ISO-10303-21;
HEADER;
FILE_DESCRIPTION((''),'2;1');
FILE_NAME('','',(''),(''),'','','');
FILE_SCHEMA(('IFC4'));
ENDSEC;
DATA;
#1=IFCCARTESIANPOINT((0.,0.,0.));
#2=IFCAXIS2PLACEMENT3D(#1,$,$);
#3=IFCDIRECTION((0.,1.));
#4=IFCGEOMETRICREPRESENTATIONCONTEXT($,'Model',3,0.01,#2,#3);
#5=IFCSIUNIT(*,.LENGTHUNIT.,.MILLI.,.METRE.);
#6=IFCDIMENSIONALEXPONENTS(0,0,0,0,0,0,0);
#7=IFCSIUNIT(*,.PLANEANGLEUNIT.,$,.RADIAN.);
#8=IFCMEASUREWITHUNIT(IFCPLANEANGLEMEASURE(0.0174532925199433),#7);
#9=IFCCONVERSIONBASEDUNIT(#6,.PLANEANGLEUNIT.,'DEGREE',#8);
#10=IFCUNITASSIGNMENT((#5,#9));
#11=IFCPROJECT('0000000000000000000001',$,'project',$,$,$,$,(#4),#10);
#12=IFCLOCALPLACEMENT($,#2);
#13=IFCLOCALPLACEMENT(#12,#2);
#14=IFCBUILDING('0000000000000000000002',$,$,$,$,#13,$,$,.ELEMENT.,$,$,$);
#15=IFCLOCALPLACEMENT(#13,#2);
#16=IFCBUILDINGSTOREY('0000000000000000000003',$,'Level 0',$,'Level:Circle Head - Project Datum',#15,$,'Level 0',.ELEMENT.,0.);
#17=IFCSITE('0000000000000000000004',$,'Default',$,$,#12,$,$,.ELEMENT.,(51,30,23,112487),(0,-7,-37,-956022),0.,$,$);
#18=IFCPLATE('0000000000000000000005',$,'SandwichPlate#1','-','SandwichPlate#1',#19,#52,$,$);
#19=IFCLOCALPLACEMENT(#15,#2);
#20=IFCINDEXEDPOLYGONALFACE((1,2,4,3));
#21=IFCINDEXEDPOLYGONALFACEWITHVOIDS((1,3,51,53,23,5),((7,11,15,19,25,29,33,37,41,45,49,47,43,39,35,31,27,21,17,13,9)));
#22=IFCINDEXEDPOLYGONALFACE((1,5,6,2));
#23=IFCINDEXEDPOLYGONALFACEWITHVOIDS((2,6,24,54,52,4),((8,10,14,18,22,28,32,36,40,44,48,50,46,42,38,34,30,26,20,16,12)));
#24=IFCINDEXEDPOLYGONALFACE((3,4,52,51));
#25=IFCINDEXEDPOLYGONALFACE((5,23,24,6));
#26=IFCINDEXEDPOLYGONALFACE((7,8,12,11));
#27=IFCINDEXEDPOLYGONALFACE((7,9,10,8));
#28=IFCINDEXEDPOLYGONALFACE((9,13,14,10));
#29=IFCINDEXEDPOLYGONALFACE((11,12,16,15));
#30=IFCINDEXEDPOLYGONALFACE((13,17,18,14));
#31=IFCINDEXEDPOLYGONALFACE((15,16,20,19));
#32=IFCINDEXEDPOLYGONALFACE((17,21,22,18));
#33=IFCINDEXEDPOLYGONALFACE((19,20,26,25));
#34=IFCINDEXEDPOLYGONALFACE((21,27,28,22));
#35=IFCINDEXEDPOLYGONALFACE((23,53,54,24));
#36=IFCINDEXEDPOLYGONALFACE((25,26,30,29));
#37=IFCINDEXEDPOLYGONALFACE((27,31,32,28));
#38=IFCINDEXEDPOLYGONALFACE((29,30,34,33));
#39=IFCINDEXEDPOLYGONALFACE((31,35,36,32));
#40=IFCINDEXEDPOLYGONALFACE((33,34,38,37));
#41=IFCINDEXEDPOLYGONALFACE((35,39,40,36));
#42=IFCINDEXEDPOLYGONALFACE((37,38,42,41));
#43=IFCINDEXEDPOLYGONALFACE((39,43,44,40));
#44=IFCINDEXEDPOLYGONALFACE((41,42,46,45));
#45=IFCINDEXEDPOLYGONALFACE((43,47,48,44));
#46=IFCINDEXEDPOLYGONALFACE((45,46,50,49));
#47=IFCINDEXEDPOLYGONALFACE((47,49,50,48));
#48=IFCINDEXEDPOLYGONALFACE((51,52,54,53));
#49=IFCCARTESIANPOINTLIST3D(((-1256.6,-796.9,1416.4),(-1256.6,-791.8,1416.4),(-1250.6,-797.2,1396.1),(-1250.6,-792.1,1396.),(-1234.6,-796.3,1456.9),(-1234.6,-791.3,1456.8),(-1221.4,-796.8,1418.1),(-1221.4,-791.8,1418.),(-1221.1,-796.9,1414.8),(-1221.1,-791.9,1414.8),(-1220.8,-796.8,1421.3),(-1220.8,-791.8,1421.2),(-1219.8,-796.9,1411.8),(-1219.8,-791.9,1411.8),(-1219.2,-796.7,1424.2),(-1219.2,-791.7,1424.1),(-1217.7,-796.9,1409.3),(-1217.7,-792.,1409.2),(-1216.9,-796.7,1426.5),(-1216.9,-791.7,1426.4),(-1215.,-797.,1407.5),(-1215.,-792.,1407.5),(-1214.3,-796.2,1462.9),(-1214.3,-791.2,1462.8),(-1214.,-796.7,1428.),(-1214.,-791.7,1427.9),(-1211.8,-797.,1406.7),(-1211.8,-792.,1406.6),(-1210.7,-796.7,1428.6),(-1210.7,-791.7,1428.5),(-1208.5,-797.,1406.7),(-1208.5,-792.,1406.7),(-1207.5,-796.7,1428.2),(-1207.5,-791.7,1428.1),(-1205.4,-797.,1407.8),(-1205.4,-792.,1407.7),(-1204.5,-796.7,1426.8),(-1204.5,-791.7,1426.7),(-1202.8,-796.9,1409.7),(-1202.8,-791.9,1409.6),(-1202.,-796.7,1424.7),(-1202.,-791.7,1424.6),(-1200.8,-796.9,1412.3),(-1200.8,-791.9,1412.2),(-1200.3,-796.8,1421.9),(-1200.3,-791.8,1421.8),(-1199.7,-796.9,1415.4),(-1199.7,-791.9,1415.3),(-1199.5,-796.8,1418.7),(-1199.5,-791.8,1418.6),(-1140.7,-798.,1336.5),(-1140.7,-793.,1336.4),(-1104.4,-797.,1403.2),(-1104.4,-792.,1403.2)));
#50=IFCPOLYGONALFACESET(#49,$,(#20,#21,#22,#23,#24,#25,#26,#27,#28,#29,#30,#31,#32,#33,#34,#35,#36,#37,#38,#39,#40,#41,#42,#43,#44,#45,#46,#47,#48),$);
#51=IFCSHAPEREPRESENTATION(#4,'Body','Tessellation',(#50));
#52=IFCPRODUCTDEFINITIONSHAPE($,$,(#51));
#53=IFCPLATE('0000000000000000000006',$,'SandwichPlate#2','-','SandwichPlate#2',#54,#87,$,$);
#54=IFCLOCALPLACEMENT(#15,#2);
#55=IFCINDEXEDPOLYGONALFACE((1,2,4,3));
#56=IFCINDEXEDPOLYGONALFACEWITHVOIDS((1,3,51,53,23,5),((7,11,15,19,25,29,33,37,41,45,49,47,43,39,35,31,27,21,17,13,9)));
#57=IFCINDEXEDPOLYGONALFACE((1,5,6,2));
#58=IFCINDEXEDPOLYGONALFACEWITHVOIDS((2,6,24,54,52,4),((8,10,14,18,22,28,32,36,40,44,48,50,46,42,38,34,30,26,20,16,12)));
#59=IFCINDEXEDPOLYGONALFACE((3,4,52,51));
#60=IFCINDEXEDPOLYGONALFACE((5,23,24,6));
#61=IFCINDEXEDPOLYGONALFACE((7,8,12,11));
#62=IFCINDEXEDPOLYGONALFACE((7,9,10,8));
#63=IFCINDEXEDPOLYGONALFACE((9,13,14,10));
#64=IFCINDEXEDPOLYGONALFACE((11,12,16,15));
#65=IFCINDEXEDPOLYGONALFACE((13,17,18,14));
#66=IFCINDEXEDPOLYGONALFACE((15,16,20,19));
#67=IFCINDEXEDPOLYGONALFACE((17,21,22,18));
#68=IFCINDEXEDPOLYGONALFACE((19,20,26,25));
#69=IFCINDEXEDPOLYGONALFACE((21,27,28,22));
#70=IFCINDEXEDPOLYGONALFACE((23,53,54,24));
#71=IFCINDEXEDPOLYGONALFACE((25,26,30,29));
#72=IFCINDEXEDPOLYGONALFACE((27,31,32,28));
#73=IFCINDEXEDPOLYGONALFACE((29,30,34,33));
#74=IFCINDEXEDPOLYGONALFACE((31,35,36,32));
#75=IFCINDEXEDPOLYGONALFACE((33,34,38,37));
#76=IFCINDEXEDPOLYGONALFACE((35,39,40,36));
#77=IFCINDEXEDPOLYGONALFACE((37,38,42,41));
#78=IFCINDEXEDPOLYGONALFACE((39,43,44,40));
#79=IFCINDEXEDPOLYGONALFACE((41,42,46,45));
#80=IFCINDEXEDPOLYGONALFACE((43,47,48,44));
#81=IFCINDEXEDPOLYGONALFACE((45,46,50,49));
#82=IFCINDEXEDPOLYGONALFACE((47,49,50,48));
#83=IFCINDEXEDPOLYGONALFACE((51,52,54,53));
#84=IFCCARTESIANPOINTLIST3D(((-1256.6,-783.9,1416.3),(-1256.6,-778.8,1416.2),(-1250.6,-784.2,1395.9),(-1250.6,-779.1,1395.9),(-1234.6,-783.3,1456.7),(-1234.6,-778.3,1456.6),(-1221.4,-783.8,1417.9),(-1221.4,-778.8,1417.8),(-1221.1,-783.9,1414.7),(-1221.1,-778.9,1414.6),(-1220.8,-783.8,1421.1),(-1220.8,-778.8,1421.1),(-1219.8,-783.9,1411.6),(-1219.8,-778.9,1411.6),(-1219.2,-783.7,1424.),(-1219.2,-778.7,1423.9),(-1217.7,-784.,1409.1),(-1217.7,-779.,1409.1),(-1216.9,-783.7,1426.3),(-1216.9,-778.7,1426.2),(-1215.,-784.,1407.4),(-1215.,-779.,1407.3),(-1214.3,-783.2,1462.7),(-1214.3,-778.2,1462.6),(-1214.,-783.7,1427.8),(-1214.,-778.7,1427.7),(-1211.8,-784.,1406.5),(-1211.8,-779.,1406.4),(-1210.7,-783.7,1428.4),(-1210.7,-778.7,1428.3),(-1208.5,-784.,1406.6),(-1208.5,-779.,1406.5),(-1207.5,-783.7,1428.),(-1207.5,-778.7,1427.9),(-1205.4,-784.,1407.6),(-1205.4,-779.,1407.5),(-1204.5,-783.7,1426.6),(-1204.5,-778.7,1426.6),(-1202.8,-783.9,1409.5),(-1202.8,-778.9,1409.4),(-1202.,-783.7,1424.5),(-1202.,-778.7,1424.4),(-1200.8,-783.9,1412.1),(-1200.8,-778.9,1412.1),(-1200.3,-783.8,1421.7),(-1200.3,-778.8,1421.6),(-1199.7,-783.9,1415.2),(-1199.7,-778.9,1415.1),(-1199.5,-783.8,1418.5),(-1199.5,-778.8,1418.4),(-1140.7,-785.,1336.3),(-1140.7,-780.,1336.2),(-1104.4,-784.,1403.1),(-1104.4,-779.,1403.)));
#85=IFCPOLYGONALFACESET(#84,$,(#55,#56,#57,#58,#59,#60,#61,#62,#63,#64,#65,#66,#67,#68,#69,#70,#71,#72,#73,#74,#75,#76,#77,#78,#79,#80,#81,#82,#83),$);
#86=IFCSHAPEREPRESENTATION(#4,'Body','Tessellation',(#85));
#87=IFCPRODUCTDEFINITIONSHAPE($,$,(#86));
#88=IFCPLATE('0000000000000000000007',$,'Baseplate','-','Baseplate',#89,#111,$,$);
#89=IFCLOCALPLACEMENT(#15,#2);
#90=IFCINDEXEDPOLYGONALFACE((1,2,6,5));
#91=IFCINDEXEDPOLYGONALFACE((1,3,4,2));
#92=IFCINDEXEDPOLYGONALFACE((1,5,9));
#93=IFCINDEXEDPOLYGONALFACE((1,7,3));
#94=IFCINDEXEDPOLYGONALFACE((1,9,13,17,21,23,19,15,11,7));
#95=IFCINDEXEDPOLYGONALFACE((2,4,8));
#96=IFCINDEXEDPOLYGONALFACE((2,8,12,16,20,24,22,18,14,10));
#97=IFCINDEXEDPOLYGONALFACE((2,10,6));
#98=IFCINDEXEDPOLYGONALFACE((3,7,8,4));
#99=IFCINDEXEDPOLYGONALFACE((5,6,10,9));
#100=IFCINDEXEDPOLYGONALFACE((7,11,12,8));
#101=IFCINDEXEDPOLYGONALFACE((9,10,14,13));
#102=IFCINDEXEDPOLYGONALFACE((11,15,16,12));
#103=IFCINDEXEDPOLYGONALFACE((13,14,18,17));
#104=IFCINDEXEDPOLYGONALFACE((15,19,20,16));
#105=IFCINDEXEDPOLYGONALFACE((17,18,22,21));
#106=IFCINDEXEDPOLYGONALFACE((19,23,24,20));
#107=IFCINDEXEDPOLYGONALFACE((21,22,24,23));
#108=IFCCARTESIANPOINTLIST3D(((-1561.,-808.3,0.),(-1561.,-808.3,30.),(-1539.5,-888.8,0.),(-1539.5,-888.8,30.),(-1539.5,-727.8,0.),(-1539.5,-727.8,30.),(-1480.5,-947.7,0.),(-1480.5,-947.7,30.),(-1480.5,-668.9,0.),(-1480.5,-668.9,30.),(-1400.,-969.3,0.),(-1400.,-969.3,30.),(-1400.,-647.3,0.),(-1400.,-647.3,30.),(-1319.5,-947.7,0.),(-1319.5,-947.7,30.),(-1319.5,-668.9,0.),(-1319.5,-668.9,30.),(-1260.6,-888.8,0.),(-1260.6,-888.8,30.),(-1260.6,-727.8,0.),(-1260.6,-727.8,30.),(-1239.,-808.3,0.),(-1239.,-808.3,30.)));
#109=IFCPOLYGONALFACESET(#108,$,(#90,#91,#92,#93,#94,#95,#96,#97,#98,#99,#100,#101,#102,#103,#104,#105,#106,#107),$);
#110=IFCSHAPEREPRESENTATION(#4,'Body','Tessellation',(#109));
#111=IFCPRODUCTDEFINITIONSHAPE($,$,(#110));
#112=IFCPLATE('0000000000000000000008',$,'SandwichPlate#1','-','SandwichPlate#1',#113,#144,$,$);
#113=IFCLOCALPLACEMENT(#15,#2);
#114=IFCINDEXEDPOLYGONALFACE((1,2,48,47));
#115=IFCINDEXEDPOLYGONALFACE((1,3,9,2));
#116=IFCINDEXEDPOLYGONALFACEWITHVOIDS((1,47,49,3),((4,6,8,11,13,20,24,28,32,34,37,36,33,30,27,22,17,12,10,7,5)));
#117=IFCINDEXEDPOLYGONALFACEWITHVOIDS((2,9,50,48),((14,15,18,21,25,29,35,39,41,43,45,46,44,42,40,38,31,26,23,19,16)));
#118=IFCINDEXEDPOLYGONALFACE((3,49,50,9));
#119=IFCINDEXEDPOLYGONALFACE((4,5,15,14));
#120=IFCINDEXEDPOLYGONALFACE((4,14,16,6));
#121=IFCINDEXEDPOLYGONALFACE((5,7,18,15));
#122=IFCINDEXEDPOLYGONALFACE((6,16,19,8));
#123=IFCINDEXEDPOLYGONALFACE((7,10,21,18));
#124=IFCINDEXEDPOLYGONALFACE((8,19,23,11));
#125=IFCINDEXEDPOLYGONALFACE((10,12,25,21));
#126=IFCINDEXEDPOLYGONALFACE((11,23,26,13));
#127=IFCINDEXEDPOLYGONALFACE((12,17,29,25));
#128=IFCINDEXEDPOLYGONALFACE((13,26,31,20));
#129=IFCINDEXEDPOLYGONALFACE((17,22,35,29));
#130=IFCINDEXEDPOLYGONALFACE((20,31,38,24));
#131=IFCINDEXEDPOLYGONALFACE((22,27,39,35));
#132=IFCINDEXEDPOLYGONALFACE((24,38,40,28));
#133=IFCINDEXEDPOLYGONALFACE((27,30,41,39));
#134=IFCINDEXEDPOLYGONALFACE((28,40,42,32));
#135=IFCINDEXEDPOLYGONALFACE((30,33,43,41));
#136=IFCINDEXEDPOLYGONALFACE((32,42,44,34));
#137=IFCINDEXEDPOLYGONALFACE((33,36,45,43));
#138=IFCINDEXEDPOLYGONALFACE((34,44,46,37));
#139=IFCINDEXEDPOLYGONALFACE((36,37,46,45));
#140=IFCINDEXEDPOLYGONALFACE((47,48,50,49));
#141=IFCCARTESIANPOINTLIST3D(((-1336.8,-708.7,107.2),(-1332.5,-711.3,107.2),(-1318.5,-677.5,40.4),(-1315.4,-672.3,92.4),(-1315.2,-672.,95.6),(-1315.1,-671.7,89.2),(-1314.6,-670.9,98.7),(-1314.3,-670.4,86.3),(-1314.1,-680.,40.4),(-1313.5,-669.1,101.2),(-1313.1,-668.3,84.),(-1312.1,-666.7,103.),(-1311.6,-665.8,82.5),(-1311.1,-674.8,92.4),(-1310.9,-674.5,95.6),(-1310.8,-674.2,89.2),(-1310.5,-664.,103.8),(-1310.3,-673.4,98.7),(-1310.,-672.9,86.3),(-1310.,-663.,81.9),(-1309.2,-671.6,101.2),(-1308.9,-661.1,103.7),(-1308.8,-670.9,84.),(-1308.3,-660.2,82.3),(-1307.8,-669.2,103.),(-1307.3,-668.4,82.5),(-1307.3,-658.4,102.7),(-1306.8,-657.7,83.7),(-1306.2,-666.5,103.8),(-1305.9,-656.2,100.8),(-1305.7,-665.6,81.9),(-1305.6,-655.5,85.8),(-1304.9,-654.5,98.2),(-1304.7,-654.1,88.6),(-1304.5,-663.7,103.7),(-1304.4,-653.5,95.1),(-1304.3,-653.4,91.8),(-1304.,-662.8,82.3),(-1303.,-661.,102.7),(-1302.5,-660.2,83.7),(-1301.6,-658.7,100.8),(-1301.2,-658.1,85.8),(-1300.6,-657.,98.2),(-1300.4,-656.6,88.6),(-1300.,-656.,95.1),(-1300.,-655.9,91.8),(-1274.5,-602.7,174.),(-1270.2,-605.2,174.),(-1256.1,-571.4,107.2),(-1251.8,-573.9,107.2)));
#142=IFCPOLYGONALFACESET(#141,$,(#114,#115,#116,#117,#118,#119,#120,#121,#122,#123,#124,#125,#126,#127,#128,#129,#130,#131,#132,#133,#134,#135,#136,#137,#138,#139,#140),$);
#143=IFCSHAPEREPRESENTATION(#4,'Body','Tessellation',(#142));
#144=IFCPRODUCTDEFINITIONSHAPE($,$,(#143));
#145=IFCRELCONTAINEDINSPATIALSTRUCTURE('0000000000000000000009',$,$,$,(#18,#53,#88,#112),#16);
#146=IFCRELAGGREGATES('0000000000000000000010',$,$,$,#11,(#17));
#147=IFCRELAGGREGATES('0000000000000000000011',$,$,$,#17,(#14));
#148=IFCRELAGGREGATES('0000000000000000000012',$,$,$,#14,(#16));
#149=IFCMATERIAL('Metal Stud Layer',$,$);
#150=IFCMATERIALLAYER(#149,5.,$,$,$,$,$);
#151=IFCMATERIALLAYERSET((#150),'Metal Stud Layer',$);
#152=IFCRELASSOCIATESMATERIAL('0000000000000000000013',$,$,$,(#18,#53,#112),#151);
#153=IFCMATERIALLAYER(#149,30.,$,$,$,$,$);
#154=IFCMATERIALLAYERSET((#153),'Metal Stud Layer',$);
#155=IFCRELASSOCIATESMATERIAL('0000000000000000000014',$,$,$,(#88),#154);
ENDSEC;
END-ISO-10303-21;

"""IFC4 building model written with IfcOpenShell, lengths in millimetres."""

from ifc_helpers import new_model, entity, si_unit, converted_unit, point, direction, frame, frame_2d, origin, origin_with_axes, origin_2d_with_axis, place, context, project, spatial, polyline, circle_curve, line_curve, trimmed, segment, composite_curve, circle, outline, extrude, material, layer, layer_set, element, save


model = new_model("IFC4")

# Units and contexts
model_context = context("Model", 3, precision=0.01, world=origin(), true_north=direction((0.0, 1.0)))
ifc_project = project(units=[si_unit("LENGTHUNIT", "METRE", prefix="MILLI"), converted_unit("PLANEANGLEUNIT", "DEGREE", entity("IfcPlaneAngleMeasure", 0.0174532925199433), si_unit("PLANEANGLEUNIT", "RADIAN"), dimensions=[0, 0, 0, 0, 0, 0, 0])], contexts=[model_context])

# Site, building, storey
site_placement = place(None, origin())
site = spatial("IfcSite", under=ifc_project, at=site_placement, Name="Default", CompositionType="ELEMENT", RefLatitude=(51, 30, 23, 112487), RefLongitude=(0, -7, -37, -956022), RefElevation=0.0)
building_placement = place(site_placement, origin())
building = spatial("IfcBuilding", under=site, at=building_placement, CompositionType="ELEMENT")
storey_placement = place(building_placement, origin())
storey = spatial("IfcBuildingStorey", under=building, at=storey_placement, Name="Level 0", ObjectType="Level:Circle Head - Project Datum", LongName="Level 0", CompositionType="ELEMENT", Elevation=0.0)

# Plates, openings
ifc_material_1 = material(Name="Metal Stud Layer")
ifc_layer_1 = layer(ifc_material_1, 5.0)
ifc_layer_set_1 = layer_set([ifc_layer_1], Name="Metal Stud Layer")
plate_1_placement = place(storey_placement, frame((-1263.7, -797.0, 1403.3), z_axis=(0.0, 0.999896, -0.014432), x_axis=(0.477218, 0.012683, 0.878693)))
plate_1 = element("IfcPlate", 1, at=plate_1_placement, inside=storey, material=ifc_layer_set_1, Name="SandwichPlate#1", Description="-", ObjectType="SandwichPlate#1", context=model_context, shape_type="SweptSolid", body=[
    extrude(outline(polyline([(0.0, 0.0), (76.0, 0.0), (76.0, 140.0), (0.0, 140.0), (0.0, 0.0)])), origin_with_axes(), (0.0, 0.0, 1.0), 5.0),
])
opening_1_placement = place(plate_1_placement, frame((0.0, 0.0, 0.0), z_axis=(0.0, 0.0, 1.0), x_axis=(1.0, 0.0, 0.0)))
element("IfcOpeningElement", 2, at=opening_1_placement, cuts=plate_1, ObjectType="Opening", context=model_context, shape_type="SweptSolid", body=[
    extrude(outline(polyline([(0.0, 0.0), (15.0, 0.0), (0.0, 15.0), (0.0, 0.0)])), origin(), (0.0, 0.0, 1.0), 5.0),
])
opening_2_placement = place(plate_1_placement, frame((0.0, 0.0, 0.0), z_axis=(0.0, 0.0, 1.0), x_axis=(1.0, 0.0, 0.0)))
element("IfcOpeningElement", 3, at=opening_2_placement, cuts=plate_1, ObjectType="Opening", context=model_context, shape_type="SweptSolid", body=[
    extrude(outline(polyline([(76.0, 0.0), (76.0, 15.0), (61.0, 0.0), (76.0, 0.0)])), origin(), (0.0, 0.0, 1.0), 5.0),
])
opening_3_placement = place(plate_1_placement, frame((38.0, 40.0, -0.5), z_axis=(0.0, 0.0, 1.0), x_axis=(0.0, 1.0, 0.0)))
element("IfcOpeningElement", 4, at=opening_3_placement, cuts=plate_1, ObjectType="Opening", context=model_context, shape_type="SweptSolid", body=[
    extrude(circle(Radius=11.0, at=origin_2d_with_axis()), origin(), (0.0, 0.0, 1.0), 6.0),
])
plate_2_placement = place(storey_placement, frame((-1263.7, -784.0, 1403.1), z_axis=(0.0, 0.999896, -0.014432), x_axis=(0.477218, 0.012683, 0.878693)))
plate_2 = element("IfcPlate", 5, at=plate_2_placement, inside=storey, material=ifc_layer_set_1, Name="SandwichPlate#2", Description="-", ObjectType="SandwichPlate#2", context=model_context, shape_type="SweptSolid", body=[
    extrude(outline(polyline([(0.0, 0.0), (76.0, 0.0), (76.0, 140.0), (0.0, 140.0), (0.0, 0.0)])), origin_with_axes(), (0.0, 0.0, 1.0), 5.0),
])
opening_4_placement = place(plate_2_placement, frame((0.0, 0.0, 0.0), z_axis=(0.0, 0.0, 1.0), x_axis=(1.0, 0.0, 0.0)))
element("IfcOpeningElement", 6, at=opening_4_placement, cuts=plate_2, ObjectType="Opening", context=model_context, shape_type="SweptSolid", body=[
    extrude(outline(polyline([(0.0, 0.0), (15.0, 0.0), (0.0, 15.0), (0.0, 0.0)])), origin(), (0.0, 0.0, 1.0), 5.0),
])
opening_5_placement = place(plate_2_placement, frame((0.0, 0.0, 0.0), z_axis=(0.0, 0.0, 1.0), x_axis=(1.0, 0.0, 0.0)))
element("IfcOpeningElement", 7, at=opening_5_placement, cuts=plate_2, ObjectType="Opening", context=model_context, shape_type="SweptSolid", body=[
    extrude(outline(polyline([(76.0, 0.0), (76.0, 15.0), (61.0, 0.0), (76.0, 0.0)])), origin(), (0.0, 0.0, 1.0), 5.0),
])
opening_6_placement = place(plate_2_placement, frame((38.0, 40.0, -0.5), z_axis=(0.0, 0.0, 1.0), x_axis=(0.0, 1.0, 0.0)))
element("IfcOpeningElement", 8, at=opening_6_placement, cuts=plate_2, ObjectType="Opening", context=model_context, shape_type="SweptSolid", body=[
    extrude(circle(Radius=11.0, at=origin_2d_with_axis()), origin(), (0.0, 0.0, 1.0), 6.0),
])
ifc_layer_2 = layer(ifc_material_1, 30.0)
ifc_layer_set_2 = layer_set([ifc_layer_2], Name="Metal Stud Layer")
plate_3_placement = place(storey_placement, frame((-1319.5, -947.7, 30.0), z_axis=(0.0, 0.0, -1.0), x_axis=(-0.866025, -0.5, 0.0)))
plate_3 = element("IfcPlate", 9, at=plate_3_placement, inside=storey, material=ifc_layer_set_2, Name="Baseplate", Description="-", ObjectType="Baseplate", context=model_context, shape_type="SweptSolid", body=[
    extrude(outline(polyline([(161.0, 0.0), (161.0, 322.0), (-161.0, 322.0), (-161.0, 0.0), (161.0, 0.0)])), origin_with_axes(), (0.0, 0.0, 1.0), 30.0),
])
opening_7_placement = place(plate_3_placement, frame((0.0, 0.0, 0.0), z_axis=(0.0, 0.0, 1.0), x_axis=(1.0, 0.0, 0.0)))
element("IfcOpeningElement", 10, at=opening_7_placement, cuts=plate_3, ObjectType="Opening", context=model_context, shape_type="SweptSolid", body=[
    extrude(outline(composite_curve([segment(trimmed(line_curve((161.0, 0.0), (0.0, 1.0), 161.0), [point((161.0, 0.0))], [point((161.0, 161.0))], True, "CARTESIAN"), True, "CONTINUOUS"), segment(trimmed(circle_curve(frame_2d((0.0, 161.0), x_axis=(-1.0, 0.0)), 161.0), [point((161.0, 161.0))], [point((0.0, 0.0))], False, "CARTESIAN"), True, "CONTINUOUS"), segment(trimmed(line_curve((0.0, 0.0), (1.0, 0.0), 161.0), [point((0.0, 0.0))], [point((161.0, 0.0))], True, "CARTESIAN"), True, "CONTINUOUS")], self_intersect="UNKNOWN")), origin(), (0.0, 0.0, 1.0), 30.0),
])
opening_8_placement = place(plate_3_placement, frame((0.0, 0.0, 0.0), z_axis=(0.0, 0.0, 1.0), x_axis=(1.0, 0.0, 0.0)))
element("IfcOpeningElement", 11, at=opening_8_placement, cuts=plate_3, ObjectType="Opening", context=model_context, shape_type="SweptSolid", body=[
    extrude(outline(composite_curve([segment(trimmed(line_curve((161.0, 322.0), (-1.0, 0.0), 161.0), [point((161.0, 322.0))], [point((0.0, 322.0))], True, "CARTESIAN"), True, "CONTINUOUS"), segment(trimmed(circle_curve(frame_2d((0.0, 161.0), x_axis=(-1.0, 0.0)), 161.0), [point((0.0, 322.0))], [point((161.0, 161.0))], False, "CARTESIAN"), True, "CONTINUOUS"), segment(trimmed(line_curve((161.0, 161.0), (0.0, 1.0), 161.0), [point((161.0, 161.0))], [point((161.0, 322.0))], True, "CARTESIAN"), True, "CONTINUOUS")], self_intersect="UNKNOWN")), origin(), (0.0, 0.0, 1.0), 30.0),
])
opening_9_placement = place(plate_3_placement, frame((0.0, 0.0, 0.0), z_axis=(0.0, 0.0, 1.0), x_axis=(1.0, 0.0, 0.0)))
element("IfcOpeningElement", 12, at=opening_9_placement, cuts=plate_3, ObjectType="Opening", context=model_context, shape_type="SweptSolid", body=[
    extrude(outline(composite_curve([segment(trimmed(line_curve((-161.0, 322.0), (0.0, -1.0), 161.0), [point((-161.0, 322.0))], [point((-161.0, 161.0))], True, "CARTESIAN"), True, "CONTINUOUS"), segment(trimmed(circle_curve(frame_2d((0.0, 161.0), x_axis=(-1.0, 0.0)), 161.0), [point((-161.0, 161.0))], [point((0.0, 322.0))], False, "CARTESIAN"), True, "CONTINUOUS"), segment(trimmed(line_curve((0.0, 322.0), (-1.0, 0.0), 161.0), [point((0.0, 322.0))], [point((-161.0, 322.0))], True, "CARTESIAN"), True, "CONTINUOUS")], self_intersect="UNKNOWN")), origin(), (0.0, 0.0, 1.0), 30.0),
])
opening_10_placement = place(plate_3_placement, frame((0.0, 0.0, 0.0), z_axis=(0.0, 0.0, 1.0), x_axis=(1.0, 0.0, 0.0)))
element("IfcOpeningElement", 13, at=opening_10_placement, cuts=plate_3, ObjectType="Opening", context=model_context, shape_type="SweptSolid", body=[
    extrude(outline(composite_curve([segment(trimmed(line_curve((-161.0, 0.0), (1.0, 0.0), 161.0), [point((-161.0, 0.0))], [point((0.0, 0.0))], True, "CARTESIAN"), True, "CONTINUOUS"), segment(trimmed(circle_curve(frame_2d((0.0, 161.0), x_axis=(-1.0, 0.0)), 161.0), [point((0.0, 0.0))], [point((-161.0, 161.0))], False, "CARTESIAN"), True, "CONTINUOUS"), segment(trimmed(line_curve((-161.0, 161.0), (0.0, -1.0), 161.0), [point((-161.0, 161.0))], [point((-161.0, 0.0))], True, "CARTESIAN"), True, "CONTINUOUS")], self_intersect="UNKNOWN")), origin(), (0.0, 0.0, 1.0), 30.0),
])

# Plate, opening
plate_4_placement = place(storey_placement, frame((-1336.8, -708.7, 107.2), z_axis=(0.86208, -0.506772, 0.0), x_axis=(0.24181, 0.411348, -0.878818)))
plate_4 = element("IfcPlate", 14, at=plate_4_placement, inside=storey, material=ifc_layer_set_1, Name="SandwichPlate#1", Description="-", ObjectType="SandwichPlate#1", context=model_context, shape_type="SweptSolid", body=[
    extrude(outline(polyline([(0.0, 0.0), (76.0, 0.0), (76.0, 140.0), (0.0, 140.0), (0.0, 0.0)])), origin_with_axes(), (0.0, 0.0, 1.0), 5.0),
])
opening_11_placement = place(plate_4_placement, frame((38.0, 40.0, -0.5), z_axis=(0.0, 0.0, 1.0), x_axis=(0.0, 1.0, 0.0)))
element("IfcOpeningElement", 15, at=opening_11_placement, cuts=plate_4, ObjectType="Opening", context=model_context, shape_type="SweptSolid", body=[
    extrude(circle(Radius=11.0, at=origin_2d_with_axis()), origin(), (0.0, 0.0, 1.0), 6.0),
])

save(model, "model.ifc")
